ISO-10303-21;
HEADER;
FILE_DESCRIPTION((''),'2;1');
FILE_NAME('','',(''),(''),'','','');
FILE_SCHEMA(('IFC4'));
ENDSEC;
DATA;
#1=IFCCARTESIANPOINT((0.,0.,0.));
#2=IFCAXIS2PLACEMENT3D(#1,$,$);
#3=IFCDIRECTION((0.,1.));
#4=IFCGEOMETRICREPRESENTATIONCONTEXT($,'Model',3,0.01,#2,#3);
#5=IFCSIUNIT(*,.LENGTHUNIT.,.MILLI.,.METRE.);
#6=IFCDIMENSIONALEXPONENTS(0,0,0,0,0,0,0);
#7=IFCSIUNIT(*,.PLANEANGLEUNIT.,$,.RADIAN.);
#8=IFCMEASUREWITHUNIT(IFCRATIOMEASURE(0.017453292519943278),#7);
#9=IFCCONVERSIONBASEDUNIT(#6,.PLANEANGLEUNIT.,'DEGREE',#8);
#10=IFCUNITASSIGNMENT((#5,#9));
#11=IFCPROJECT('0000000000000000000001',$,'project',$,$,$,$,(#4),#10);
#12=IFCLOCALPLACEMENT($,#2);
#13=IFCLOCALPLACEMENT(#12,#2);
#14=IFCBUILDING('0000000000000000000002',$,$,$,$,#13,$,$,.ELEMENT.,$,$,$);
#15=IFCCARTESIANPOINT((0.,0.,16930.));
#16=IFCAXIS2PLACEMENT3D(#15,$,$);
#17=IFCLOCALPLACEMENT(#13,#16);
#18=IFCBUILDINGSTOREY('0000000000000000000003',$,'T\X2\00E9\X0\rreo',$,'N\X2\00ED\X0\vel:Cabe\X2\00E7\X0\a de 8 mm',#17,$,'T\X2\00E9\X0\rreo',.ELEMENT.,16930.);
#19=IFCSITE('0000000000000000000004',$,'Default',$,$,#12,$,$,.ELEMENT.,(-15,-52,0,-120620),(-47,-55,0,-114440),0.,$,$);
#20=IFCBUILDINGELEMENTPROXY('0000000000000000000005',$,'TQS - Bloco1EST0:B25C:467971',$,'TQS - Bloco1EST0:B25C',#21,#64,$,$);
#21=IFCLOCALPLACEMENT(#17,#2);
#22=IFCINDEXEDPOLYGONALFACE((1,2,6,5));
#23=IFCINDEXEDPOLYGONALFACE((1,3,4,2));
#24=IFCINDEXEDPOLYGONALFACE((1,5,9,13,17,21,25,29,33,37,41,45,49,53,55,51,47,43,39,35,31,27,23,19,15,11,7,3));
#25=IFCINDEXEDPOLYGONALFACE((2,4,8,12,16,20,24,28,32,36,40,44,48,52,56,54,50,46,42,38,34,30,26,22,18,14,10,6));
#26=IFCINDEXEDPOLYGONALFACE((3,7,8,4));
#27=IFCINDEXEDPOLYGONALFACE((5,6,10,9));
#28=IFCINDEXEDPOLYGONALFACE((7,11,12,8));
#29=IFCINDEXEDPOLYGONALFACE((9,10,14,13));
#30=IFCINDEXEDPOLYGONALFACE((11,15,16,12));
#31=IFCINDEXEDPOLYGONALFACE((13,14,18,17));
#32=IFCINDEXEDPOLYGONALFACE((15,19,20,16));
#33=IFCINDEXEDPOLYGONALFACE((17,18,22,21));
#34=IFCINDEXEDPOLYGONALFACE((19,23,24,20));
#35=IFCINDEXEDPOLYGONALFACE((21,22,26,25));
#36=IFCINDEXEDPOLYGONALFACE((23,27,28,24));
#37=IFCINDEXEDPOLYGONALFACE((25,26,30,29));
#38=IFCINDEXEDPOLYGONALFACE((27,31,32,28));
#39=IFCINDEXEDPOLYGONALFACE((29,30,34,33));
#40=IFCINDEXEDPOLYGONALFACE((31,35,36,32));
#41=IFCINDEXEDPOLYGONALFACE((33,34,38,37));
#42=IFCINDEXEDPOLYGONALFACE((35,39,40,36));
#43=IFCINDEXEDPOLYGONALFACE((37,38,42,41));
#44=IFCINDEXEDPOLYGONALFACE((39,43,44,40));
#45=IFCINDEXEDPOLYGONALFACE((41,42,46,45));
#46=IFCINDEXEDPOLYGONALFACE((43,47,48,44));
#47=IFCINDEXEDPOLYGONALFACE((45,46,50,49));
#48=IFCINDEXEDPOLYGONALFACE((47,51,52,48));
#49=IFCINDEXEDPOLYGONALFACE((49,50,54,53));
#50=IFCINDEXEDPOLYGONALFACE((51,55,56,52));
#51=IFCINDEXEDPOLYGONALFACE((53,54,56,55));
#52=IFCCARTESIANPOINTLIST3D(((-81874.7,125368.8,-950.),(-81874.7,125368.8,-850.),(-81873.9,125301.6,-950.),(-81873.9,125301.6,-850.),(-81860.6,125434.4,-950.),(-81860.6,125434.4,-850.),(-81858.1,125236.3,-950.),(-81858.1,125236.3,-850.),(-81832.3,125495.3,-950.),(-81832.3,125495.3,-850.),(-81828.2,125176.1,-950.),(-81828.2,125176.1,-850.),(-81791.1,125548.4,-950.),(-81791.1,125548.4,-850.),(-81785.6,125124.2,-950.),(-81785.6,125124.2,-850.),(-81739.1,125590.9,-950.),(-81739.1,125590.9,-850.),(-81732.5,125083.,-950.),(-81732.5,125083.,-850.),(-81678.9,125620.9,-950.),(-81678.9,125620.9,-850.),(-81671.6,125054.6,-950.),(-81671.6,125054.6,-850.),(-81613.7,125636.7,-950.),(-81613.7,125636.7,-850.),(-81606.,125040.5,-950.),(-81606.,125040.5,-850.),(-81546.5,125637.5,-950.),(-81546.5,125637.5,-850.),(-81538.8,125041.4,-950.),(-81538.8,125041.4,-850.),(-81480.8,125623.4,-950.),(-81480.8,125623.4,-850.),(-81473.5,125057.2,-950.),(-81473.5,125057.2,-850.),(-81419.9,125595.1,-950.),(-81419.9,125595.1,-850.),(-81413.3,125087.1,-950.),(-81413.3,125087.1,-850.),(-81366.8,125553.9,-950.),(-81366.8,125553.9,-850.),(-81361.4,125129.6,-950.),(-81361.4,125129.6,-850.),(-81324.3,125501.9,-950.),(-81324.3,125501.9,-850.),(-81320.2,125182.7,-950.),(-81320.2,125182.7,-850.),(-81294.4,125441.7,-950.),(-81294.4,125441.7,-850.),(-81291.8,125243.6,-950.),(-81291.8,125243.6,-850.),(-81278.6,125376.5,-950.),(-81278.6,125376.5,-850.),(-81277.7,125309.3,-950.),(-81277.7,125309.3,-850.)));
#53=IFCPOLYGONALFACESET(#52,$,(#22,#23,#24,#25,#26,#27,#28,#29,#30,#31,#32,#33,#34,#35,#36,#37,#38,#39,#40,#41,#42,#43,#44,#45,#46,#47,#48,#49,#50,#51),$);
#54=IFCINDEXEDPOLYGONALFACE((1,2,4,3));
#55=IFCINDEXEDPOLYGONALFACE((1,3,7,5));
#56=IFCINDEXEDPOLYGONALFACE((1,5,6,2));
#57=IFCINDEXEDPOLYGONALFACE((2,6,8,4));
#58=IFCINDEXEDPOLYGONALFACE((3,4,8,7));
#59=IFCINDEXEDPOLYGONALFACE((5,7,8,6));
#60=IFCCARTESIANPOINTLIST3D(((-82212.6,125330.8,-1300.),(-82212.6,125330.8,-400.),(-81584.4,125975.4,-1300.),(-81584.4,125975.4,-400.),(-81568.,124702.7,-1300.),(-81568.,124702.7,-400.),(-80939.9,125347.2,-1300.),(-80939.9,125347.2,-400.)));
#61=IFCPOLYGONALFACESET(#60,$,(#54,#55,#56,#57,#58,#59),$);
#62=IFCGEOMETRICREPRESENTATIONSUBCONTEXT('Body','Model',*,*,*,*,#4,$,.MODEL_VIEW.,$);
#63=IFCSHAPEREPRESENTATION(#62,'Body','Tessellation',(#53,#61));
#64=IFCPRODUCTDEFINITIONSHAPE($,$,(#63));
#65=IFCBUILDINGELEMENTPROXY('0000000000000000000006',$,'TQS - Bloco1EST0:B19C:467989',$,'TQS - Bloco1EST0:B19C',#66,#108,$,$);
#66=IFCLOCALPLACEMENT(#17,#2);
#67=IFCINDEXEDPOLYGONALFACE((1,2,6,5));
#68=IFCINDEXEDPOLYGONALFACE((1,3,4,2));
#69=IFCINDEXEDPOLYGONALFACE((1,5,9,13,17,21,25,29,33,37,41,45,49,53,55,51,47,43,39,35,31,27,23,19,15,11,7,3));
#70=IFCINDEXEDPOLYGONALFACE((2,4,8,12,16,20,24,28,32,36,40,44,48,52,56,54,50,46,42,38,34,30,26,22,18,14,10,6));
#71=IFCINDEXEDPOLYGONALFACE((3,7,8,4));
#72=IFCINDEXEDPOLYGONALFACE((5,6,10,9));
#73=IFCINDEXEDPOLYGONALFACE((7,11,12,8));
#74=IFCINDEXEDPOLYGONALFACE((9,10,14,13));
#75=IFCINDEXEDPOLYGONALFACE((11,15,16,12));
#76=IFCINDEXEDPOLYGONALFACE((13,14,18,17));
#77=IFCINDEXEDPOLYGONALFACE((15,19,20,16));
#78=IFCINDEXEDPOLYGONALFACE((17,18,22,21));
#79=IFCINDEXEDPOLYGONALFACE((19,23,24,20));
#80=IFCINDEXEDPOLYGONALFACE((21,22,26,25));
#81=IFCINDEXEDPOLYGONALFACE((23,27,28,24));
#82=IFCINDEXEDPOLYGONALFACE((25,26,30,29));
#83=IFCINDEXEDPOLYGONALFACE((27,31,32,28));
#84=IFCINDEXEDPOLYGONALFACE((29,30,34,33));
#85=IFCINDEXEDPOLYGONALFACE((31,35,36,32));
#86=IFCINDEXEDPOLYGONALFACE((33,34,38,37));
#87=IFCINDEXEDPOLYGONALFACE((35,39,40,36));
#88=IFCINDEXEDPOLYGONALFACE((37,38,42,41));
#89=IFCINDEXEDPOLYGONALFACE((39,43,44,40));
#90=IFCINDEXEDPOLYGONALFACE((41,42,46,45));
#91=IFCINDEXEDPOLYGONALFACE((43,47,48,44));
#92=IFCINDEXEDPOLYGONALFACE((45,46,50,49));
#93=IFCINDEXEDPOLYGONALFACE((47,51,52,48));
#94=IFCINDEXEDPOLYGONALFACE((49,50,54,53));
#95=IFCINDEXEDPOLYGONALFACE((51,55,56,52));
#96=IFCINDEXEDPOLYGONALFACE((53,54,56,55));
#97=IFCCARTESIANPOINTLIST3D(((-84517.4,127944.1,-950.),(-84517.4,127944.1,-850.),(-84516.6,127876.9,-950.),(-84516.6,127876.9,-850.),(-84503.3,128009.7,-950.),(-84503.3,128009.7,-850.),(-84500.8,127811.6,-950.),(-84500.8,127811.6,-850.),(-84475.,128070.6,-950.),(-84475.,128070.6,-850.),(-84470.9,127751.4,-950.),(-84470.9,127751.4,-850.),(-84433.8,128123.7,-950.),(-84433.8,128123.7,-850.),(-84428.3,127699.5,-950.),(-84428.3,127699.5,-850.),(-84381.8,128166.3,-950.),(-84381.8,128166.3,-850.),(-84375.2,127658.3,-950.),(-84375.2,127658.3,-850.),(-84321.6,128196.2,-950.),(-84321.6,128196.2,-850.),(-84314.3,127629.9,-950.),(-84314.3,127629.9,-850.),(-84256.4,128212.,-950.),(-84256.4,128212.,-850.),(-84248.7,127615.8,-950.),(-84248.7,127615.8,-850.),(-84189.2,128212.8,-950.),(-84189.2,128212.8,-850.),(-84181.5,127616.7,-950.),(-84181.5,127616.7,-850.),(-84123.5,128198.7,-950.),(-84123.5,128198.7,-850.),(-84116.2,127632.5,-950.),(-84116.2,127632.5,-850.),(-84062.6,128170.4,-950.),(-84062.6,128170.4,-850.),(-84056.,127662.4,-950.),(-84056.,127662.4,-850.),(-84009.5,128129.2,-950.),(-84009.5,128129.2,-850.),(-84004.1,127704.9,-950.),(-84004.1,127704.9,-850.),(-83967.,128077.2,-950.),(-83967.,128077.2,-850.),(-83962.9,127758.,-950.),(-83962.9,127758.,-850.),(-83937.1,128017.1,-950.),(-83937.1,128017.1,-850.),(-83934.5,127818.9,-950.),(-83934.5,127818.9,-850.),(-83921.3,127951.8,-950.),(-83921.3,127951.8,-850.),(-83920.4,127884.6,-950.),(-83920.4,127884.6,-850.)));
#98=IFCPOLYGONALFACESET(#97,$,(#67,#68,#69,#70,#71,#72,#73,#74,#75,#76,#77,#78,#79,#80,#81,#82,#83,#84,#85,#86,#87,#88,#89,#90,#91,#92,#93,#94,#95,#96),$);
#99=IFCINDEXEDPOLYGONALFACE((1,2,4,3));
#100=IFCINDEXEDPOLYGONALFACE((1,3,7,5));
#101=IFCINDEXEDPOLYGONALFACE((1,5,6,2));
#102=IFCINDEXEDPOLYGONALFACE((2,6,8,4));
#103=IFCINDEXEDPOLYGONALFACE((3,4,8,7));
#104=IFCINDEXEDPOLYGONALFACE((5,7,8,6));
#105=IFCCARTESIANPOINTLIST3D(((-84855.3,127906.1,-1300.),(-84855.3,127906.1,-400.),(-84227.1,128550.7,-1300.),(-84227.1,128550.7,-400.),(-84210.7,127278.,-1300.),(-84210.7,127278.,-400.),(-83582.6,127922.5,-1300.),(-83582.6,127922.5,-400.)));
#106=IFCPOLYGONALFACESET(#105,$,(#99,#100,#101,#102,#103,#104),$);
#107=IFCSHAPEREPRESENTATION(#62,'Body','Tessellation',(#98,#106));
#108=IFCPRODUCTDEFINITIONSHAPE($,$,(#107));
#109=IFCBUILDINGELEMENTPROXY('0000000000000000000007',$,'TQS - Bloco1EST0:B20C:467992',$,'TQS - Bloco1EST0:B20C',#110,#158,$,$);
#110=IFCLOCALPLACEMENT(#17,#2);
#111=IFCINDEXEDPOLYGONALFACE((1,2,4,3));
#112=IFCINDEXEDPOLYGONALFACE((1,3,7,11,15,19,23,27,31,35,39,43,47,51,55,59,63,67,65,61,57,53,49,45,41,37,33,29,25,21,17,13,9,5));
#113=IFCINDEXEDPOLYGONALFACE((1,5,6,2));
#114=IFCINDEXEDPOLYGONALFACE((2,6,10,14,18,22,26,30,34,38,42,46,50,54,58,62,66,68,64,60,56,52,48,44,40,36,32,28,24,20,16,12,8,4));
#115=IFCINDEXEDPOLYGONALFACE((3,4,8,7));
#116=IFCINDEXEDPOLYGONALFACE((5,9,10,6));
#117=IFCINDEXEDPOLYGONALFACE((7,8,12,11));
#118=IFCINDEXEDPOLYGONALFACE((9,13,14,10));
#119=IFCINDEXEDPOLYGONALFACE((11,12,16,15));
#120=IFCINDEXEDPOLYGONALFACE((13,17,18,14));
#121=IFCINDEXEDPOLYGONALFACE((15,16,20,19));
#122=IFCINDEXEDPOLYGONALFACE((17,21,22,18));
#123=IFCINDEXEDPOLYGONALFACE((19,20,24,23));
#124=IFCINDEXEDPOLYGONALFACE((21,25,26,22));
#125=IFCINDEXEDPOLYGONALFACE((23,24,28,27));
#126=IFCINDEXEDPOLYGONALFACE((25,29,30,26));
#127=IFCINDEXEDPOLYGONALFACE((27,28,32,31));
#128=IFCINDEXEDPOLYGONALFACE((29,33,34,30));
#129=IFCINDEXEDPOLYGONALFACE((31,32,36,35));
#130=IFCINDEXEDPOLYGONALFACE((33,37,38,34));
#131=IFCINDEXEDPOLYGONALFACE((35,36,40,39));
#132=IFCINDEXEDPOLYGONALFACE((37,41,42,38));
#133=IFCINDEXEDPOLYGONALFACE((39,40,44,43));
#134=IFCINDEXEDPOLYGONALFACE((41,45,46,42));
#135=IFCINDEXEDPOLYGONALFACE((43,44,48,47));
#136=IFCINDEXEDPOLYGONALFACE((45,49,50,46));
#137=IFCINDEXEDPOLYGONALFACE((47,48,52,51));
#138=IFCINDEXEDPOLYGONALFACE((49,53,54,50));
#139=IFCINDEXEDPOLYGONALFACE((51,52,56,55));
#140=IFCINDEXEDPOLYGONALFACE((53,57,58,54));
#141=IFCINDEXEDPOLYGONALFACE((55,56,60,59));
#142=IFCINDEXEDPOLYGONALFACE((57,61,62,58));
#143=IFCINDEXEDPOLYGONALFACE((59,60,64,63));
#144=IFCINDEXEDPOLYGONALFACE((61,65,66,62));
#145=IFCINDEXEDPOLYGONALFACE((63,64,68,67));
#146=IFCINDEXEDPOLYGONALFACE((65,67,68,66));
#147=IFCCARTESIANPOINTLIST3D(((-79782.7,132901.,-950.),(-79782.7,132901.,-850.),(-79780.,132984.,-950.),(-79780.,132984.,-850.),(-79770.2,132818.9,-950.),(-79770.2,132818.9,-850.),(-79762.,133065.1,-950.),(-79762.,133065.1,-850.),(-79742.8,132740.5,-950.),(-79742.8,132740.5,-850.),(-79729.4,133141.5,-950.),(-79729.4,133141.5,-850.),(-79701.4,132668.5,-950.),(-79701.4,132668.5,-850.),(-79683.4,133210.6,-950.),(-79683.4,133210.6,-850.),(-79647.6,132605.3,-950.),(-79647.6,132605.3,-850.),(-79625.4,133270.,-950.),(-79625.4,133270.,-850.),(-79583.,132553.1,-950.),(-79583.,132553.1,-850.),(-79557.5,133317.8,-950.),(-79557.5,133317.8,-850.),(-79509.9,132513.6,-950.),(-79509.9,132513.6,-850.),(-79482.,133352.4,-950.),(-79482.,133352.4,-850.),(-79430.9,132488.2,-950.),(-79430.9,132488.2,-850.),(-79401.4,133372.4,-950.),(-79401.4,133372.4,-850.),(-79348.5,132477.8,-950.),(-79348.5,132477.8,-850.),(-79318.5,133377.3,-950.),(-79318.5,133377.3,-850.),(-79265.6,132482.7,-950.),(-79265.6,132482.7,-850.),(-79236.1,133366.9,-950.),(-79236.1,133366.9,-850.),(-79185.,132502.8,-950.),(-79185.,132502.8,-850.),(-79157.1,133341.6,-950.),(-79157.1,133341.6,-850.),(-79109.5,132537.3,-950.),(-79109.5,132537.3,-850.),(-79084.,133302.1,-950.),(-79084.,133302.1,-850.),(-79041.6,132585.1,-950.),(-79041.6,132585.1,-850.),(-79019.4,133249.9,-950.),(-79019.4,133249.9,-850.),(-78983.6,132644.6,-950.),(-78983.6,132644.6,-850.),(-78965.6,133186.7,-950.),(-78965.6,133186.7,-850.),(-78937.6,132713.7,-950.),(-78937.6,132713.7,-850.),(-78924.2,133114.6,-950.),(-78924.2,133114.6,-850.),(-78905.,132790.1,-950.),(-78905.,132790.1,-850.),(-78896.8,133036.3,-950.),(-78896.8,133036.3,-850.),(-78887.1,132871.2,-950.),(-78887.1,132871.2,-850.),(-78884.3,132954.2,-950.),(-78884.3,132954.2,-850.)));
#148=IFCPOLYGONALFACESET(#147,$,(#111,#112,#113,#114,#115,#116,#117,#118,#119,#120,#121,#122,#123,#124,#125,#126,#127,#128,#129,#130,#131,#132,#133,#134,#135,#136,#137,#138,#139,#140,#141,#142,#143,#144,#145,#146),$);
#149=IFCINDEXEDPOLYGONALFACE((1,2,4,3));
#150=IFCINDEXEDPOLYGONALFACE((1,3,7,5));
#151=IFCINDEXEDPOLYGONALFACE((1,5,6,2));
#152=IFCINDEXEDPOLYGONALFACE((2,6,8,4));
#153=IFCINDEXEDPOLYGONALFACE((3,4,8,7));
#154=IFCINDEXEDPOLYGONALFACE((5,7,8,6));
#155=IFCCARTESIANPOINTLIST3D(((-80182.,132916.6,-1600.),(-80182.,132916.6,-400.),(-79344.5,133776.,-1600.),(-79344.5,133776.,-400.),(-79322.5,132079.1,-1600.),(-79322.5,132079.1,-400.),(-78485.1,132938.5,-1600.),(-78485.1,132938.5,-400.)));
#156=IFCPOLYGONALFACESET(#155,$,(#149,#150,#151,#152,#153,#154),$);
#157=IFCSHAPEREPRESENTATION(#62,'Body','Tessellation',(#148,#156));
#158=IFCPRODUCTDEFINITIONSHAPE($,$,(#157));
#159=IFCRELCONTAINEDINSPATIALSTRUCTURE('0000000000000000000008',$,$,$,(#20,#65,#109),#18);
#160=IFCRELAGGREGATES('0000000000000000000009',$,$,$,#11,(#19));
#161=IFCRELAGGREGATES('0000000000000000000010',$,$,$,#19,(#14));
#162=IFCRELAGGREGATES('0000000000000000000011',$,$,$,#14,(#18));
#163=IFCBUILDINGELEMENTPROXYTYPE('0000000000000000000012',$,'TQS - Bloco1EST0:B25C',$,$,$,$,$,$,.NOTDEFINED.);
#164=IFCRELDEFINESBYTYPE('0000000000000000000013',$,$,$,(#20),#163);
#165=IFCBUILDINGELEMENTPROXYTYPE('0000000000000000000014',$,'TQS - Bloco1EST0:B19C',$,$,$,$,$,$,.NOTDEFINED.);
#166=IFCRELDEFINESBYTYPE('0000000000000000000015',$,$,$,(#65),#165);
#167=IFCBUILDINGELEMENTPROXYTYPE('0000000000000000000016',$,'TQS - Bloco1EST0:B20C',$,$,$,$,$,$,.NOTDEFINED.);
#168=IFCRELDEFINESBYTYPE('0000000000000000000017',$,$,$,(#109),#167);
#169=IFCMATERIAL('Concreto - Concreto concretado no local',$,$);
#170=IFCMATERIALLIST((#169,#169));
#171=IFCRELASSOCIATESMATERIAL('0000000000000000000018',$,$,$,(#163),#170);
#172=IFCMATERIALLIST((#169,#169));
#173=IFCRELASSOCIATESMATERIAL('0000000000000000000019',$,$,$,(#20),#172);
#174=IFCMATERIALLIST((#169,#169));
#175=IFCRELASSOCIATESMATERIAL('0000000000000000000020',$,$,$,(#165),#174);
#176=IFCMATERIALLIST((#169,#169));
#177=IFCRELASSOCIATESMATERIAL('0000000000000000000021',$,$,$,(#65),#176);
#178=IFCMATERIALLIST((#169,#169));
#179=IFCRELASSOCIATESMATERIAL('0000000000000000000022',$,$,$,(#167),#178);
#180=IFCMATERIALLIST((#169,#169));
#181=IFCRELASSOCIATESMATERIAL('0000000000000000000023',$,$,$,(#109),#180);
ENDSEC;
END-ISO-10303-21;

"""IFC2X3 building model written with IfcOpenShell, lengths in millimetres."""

from ifc_helpers import new_model, entity, si_unit, converted_unit, direction, frame, frame_2d, origin, origin_2d_with_axis, place, context, subcontext, project, spatial, rectangle, circle, extrude, source, transform, mapped, material, material_list, type_object, type_shapes, element, save


model = new_model("IFC2X3")

# Units and contexts
model_context = context("Model", 3, precision=0.01, world=origin(), true_north=direction((0.0, 1.0)))
body_context = subcontext(model_context, "Body", "Model", "MODEL_VIEW")
ifc_project = project(units=[si_unit("LENGTHUNIT", "METRE", prefix="MILLI"), converted_unit("PLANEANGLEUNIT", "DEGREE", entity("IfcRatioMeasure", 0.017453292519943278), si_unit("PLANEANGLEUNIT", "RADIAN"), dimensions=[0, 0, 0, 0, 0, 0, 0])], contexts=[model_context])

# Site, building, storey
site_placement = place(None, origin())
site = spatial("IfcSite", under=ifc_project, at=site_placement, Name="Default", CompositionType="ELEMENT", RefLatitude=(-15, -52, 0, -120620), RefLongitude=(-47, -55, 0, -114440), RefElevation=0.0)
building_placement = place(site_placement, origin())
building = spatial("IfcBuilding", under=site, at=building_placement, CompositionType="ELEMENT")
storey_placement = place(building_placement, frame((0.0, 0.0, 16930.0)))
storey = spatial("IfcBuildingStorey", under=building, at=storey_placement, Name="Térreo", ObjectType="Nível:Cabeça de 8 mm", LongName="Térreo", CompositionType="ELEMENT", Elevation=16930.0)

# Building element proxies
ifc_material_1 = material(Name="Concreto - Concreto concretado no local")
ifc_material_list_1 = material_list([ifc_material_1, ifc_material_1])
ifc_material_list_2 = material_list([ifc_material_1, ifc_material_1])
building_element_proxy_type_1 = type_object("IfcBuildingElementProxyType", Name="TQS - Bloco1EST0:B25C", PredefinedType="NOTDEFINED", material=ifc_material_list_2)
shared_shape_1 = source(origin(), body_context, "Body", "SweptSolid", [
    extrude(circle(Radius=300.0, at=frame_2d((0.0, 0.0), x_axis=(1.0, 0.0))), frame((0.0, 0.0, -550.0)), (0.0, 0.0, 1.0), 100.0),
    extrude(rectangle(XDim=900.0, YDim=900.0, at=origin_2d_with_axis()), frame((0.0, 0.0, -900.0), z_axis=(0.0, 0.0, 1.0), x_axis=(-1.0, 0.0, 0.0)), (0.0, 0.0, 1.0), 900.0),
])
type_shapes(building_element_proxy_type_1, [shared_shape_1])
proxy_1_placement = place(storey_placement, frame((-81576.2, 125339.0, -400.0), z_axis=(0.0, 0.0, 1.0), x_axis=(0.697915, 0.71618, 0.0)))
element("IfcBuildingElementProxy", 1, at=proxy_1_placement, inside=storey, type_object=building_element_proxy_type_1, material=ifc_material_list_1, Name="TQS - Bloco1EST0:B25C:467971", ObjectType="TQS - Bloco1EST0:B25C", context=body_context, shape_type="MappedRepresentation", body=[
    mapped(shared_shape_1, transform((0.0, 0.0, 0.0), scale=1.0)),
])
ifc_material_list_3 = material_list([ifc_material_1, ifc_material_1])
ifc_material_list_4 = material_list([ifc_material_1, ifc_material_1])
building_element_proxy_type_2 = type_object("IfcBuildingElementProxyType", Name="TQS - Bloco1EST0:B19C", PredefinedType="NOTDEFINED", material=ifc_material_list_4)
shared_shape_2 = source(origin(), body_context, "Body", "SweptSolid", [
    extrude(circle(Radius=300.0, at=frame_2d((0.0, 0.0), x_axis=(1.0, 0.0))), frame((0.0, 0.0, -550.0)), (0.0, 0.0, 1.0), 100.0),
    extrude(rectangle(XDim=900.0, YDim=900.0, at=origin_2d_with_axis()), frame((0.0, 0.0, -900.0), z_axis=(0.0, 0.0, 1.0), x_axis=(-1.0, 0.0, 0.0)), (0.0, 0.0, 1.0), 900.0),
])
type_shapes(building_element_proxy_type_2, [shared_shape_2])
proxy_2_placement = place(storey_placement, frame((-84218.9, 127914.3, -400.0), z_axis=(0.0, 0.0, 1.0), x_axis=(0.697915, 0.71618, 0.0)))
element("IfcBuildingElementProxy", 2, at=proxy_2_placement, inside=storey, type_object=building_element_proxy_type_2, material=ifc_material_list_3, Name="TQS - Bloco1EST0:B19C:467989", ObjectType="TQS - Bloco1EST0:B19C", context=body_context, shape_type="MappedRepresentation", body=[
    mapped(shared_shape_2, transform((0.0, 0.0, 0.0), scale=1.0)),
])
ifc_material_list_5 = material_list([ifc_material_1, ifc_material_1])
ifc_material_list_6 = material_list([ifc_material_1, ifc_material_1])
building_element_proxy_type_3 = type_object("IfcBuildingElementProxyType", Name="TQS - Bloco1EST0:B20C", PredefinedType="NOTDEFINED", material=ifc_material_list_6)
shared_shape_3 = source(origin(), body_context, "Body", "SweptSolid", [
    extrude(circle(Radius=450.0, at=frame_2d((0.0, 0.0), x_axis=(1.0, 0.0))), frame((0.0, 0.0, -550.0)), (0.0, 0.0, 1.0), 100.0),
    extrude(rectangle(XDim=1200.0, YDim=1200.0, at=origin_2d_with_axis()), frame((0.0, 0.0, -1200.0), z_axis=(0.0, 0.0, 1.0), x_axis=(-1.0, 0.0, 0.0)), (0.0, 0.0, 1.0), 1200.0),
])
type_shapes(building_element_proxy_type_3, [shared_shape_3])
proxy_3_placement = place(storey_placement, frame((-79333.5, 132927.6, -400.0), z_axis=(0.0, 0.0, 1.0), x_axis=(0.697915, 0.71618, 0.0)))
element("IfcBuildingElementProxy", 3, at=proxy_3_placement, inside=storey, type_object=building_element_proxy_type_3, material=ifc_material_list_5, Name="TQS - Bloco1EST0:B20C:467992", ObjectType="TQS - Bloco1EST0:B20C", context=body_context, shape_type="MappedRepresentation", body=[
    mapped(shared_shape_3, transform((0.0, 0.0, 0.0), scale=1.0)),
])

save(model, "model.ifc")
